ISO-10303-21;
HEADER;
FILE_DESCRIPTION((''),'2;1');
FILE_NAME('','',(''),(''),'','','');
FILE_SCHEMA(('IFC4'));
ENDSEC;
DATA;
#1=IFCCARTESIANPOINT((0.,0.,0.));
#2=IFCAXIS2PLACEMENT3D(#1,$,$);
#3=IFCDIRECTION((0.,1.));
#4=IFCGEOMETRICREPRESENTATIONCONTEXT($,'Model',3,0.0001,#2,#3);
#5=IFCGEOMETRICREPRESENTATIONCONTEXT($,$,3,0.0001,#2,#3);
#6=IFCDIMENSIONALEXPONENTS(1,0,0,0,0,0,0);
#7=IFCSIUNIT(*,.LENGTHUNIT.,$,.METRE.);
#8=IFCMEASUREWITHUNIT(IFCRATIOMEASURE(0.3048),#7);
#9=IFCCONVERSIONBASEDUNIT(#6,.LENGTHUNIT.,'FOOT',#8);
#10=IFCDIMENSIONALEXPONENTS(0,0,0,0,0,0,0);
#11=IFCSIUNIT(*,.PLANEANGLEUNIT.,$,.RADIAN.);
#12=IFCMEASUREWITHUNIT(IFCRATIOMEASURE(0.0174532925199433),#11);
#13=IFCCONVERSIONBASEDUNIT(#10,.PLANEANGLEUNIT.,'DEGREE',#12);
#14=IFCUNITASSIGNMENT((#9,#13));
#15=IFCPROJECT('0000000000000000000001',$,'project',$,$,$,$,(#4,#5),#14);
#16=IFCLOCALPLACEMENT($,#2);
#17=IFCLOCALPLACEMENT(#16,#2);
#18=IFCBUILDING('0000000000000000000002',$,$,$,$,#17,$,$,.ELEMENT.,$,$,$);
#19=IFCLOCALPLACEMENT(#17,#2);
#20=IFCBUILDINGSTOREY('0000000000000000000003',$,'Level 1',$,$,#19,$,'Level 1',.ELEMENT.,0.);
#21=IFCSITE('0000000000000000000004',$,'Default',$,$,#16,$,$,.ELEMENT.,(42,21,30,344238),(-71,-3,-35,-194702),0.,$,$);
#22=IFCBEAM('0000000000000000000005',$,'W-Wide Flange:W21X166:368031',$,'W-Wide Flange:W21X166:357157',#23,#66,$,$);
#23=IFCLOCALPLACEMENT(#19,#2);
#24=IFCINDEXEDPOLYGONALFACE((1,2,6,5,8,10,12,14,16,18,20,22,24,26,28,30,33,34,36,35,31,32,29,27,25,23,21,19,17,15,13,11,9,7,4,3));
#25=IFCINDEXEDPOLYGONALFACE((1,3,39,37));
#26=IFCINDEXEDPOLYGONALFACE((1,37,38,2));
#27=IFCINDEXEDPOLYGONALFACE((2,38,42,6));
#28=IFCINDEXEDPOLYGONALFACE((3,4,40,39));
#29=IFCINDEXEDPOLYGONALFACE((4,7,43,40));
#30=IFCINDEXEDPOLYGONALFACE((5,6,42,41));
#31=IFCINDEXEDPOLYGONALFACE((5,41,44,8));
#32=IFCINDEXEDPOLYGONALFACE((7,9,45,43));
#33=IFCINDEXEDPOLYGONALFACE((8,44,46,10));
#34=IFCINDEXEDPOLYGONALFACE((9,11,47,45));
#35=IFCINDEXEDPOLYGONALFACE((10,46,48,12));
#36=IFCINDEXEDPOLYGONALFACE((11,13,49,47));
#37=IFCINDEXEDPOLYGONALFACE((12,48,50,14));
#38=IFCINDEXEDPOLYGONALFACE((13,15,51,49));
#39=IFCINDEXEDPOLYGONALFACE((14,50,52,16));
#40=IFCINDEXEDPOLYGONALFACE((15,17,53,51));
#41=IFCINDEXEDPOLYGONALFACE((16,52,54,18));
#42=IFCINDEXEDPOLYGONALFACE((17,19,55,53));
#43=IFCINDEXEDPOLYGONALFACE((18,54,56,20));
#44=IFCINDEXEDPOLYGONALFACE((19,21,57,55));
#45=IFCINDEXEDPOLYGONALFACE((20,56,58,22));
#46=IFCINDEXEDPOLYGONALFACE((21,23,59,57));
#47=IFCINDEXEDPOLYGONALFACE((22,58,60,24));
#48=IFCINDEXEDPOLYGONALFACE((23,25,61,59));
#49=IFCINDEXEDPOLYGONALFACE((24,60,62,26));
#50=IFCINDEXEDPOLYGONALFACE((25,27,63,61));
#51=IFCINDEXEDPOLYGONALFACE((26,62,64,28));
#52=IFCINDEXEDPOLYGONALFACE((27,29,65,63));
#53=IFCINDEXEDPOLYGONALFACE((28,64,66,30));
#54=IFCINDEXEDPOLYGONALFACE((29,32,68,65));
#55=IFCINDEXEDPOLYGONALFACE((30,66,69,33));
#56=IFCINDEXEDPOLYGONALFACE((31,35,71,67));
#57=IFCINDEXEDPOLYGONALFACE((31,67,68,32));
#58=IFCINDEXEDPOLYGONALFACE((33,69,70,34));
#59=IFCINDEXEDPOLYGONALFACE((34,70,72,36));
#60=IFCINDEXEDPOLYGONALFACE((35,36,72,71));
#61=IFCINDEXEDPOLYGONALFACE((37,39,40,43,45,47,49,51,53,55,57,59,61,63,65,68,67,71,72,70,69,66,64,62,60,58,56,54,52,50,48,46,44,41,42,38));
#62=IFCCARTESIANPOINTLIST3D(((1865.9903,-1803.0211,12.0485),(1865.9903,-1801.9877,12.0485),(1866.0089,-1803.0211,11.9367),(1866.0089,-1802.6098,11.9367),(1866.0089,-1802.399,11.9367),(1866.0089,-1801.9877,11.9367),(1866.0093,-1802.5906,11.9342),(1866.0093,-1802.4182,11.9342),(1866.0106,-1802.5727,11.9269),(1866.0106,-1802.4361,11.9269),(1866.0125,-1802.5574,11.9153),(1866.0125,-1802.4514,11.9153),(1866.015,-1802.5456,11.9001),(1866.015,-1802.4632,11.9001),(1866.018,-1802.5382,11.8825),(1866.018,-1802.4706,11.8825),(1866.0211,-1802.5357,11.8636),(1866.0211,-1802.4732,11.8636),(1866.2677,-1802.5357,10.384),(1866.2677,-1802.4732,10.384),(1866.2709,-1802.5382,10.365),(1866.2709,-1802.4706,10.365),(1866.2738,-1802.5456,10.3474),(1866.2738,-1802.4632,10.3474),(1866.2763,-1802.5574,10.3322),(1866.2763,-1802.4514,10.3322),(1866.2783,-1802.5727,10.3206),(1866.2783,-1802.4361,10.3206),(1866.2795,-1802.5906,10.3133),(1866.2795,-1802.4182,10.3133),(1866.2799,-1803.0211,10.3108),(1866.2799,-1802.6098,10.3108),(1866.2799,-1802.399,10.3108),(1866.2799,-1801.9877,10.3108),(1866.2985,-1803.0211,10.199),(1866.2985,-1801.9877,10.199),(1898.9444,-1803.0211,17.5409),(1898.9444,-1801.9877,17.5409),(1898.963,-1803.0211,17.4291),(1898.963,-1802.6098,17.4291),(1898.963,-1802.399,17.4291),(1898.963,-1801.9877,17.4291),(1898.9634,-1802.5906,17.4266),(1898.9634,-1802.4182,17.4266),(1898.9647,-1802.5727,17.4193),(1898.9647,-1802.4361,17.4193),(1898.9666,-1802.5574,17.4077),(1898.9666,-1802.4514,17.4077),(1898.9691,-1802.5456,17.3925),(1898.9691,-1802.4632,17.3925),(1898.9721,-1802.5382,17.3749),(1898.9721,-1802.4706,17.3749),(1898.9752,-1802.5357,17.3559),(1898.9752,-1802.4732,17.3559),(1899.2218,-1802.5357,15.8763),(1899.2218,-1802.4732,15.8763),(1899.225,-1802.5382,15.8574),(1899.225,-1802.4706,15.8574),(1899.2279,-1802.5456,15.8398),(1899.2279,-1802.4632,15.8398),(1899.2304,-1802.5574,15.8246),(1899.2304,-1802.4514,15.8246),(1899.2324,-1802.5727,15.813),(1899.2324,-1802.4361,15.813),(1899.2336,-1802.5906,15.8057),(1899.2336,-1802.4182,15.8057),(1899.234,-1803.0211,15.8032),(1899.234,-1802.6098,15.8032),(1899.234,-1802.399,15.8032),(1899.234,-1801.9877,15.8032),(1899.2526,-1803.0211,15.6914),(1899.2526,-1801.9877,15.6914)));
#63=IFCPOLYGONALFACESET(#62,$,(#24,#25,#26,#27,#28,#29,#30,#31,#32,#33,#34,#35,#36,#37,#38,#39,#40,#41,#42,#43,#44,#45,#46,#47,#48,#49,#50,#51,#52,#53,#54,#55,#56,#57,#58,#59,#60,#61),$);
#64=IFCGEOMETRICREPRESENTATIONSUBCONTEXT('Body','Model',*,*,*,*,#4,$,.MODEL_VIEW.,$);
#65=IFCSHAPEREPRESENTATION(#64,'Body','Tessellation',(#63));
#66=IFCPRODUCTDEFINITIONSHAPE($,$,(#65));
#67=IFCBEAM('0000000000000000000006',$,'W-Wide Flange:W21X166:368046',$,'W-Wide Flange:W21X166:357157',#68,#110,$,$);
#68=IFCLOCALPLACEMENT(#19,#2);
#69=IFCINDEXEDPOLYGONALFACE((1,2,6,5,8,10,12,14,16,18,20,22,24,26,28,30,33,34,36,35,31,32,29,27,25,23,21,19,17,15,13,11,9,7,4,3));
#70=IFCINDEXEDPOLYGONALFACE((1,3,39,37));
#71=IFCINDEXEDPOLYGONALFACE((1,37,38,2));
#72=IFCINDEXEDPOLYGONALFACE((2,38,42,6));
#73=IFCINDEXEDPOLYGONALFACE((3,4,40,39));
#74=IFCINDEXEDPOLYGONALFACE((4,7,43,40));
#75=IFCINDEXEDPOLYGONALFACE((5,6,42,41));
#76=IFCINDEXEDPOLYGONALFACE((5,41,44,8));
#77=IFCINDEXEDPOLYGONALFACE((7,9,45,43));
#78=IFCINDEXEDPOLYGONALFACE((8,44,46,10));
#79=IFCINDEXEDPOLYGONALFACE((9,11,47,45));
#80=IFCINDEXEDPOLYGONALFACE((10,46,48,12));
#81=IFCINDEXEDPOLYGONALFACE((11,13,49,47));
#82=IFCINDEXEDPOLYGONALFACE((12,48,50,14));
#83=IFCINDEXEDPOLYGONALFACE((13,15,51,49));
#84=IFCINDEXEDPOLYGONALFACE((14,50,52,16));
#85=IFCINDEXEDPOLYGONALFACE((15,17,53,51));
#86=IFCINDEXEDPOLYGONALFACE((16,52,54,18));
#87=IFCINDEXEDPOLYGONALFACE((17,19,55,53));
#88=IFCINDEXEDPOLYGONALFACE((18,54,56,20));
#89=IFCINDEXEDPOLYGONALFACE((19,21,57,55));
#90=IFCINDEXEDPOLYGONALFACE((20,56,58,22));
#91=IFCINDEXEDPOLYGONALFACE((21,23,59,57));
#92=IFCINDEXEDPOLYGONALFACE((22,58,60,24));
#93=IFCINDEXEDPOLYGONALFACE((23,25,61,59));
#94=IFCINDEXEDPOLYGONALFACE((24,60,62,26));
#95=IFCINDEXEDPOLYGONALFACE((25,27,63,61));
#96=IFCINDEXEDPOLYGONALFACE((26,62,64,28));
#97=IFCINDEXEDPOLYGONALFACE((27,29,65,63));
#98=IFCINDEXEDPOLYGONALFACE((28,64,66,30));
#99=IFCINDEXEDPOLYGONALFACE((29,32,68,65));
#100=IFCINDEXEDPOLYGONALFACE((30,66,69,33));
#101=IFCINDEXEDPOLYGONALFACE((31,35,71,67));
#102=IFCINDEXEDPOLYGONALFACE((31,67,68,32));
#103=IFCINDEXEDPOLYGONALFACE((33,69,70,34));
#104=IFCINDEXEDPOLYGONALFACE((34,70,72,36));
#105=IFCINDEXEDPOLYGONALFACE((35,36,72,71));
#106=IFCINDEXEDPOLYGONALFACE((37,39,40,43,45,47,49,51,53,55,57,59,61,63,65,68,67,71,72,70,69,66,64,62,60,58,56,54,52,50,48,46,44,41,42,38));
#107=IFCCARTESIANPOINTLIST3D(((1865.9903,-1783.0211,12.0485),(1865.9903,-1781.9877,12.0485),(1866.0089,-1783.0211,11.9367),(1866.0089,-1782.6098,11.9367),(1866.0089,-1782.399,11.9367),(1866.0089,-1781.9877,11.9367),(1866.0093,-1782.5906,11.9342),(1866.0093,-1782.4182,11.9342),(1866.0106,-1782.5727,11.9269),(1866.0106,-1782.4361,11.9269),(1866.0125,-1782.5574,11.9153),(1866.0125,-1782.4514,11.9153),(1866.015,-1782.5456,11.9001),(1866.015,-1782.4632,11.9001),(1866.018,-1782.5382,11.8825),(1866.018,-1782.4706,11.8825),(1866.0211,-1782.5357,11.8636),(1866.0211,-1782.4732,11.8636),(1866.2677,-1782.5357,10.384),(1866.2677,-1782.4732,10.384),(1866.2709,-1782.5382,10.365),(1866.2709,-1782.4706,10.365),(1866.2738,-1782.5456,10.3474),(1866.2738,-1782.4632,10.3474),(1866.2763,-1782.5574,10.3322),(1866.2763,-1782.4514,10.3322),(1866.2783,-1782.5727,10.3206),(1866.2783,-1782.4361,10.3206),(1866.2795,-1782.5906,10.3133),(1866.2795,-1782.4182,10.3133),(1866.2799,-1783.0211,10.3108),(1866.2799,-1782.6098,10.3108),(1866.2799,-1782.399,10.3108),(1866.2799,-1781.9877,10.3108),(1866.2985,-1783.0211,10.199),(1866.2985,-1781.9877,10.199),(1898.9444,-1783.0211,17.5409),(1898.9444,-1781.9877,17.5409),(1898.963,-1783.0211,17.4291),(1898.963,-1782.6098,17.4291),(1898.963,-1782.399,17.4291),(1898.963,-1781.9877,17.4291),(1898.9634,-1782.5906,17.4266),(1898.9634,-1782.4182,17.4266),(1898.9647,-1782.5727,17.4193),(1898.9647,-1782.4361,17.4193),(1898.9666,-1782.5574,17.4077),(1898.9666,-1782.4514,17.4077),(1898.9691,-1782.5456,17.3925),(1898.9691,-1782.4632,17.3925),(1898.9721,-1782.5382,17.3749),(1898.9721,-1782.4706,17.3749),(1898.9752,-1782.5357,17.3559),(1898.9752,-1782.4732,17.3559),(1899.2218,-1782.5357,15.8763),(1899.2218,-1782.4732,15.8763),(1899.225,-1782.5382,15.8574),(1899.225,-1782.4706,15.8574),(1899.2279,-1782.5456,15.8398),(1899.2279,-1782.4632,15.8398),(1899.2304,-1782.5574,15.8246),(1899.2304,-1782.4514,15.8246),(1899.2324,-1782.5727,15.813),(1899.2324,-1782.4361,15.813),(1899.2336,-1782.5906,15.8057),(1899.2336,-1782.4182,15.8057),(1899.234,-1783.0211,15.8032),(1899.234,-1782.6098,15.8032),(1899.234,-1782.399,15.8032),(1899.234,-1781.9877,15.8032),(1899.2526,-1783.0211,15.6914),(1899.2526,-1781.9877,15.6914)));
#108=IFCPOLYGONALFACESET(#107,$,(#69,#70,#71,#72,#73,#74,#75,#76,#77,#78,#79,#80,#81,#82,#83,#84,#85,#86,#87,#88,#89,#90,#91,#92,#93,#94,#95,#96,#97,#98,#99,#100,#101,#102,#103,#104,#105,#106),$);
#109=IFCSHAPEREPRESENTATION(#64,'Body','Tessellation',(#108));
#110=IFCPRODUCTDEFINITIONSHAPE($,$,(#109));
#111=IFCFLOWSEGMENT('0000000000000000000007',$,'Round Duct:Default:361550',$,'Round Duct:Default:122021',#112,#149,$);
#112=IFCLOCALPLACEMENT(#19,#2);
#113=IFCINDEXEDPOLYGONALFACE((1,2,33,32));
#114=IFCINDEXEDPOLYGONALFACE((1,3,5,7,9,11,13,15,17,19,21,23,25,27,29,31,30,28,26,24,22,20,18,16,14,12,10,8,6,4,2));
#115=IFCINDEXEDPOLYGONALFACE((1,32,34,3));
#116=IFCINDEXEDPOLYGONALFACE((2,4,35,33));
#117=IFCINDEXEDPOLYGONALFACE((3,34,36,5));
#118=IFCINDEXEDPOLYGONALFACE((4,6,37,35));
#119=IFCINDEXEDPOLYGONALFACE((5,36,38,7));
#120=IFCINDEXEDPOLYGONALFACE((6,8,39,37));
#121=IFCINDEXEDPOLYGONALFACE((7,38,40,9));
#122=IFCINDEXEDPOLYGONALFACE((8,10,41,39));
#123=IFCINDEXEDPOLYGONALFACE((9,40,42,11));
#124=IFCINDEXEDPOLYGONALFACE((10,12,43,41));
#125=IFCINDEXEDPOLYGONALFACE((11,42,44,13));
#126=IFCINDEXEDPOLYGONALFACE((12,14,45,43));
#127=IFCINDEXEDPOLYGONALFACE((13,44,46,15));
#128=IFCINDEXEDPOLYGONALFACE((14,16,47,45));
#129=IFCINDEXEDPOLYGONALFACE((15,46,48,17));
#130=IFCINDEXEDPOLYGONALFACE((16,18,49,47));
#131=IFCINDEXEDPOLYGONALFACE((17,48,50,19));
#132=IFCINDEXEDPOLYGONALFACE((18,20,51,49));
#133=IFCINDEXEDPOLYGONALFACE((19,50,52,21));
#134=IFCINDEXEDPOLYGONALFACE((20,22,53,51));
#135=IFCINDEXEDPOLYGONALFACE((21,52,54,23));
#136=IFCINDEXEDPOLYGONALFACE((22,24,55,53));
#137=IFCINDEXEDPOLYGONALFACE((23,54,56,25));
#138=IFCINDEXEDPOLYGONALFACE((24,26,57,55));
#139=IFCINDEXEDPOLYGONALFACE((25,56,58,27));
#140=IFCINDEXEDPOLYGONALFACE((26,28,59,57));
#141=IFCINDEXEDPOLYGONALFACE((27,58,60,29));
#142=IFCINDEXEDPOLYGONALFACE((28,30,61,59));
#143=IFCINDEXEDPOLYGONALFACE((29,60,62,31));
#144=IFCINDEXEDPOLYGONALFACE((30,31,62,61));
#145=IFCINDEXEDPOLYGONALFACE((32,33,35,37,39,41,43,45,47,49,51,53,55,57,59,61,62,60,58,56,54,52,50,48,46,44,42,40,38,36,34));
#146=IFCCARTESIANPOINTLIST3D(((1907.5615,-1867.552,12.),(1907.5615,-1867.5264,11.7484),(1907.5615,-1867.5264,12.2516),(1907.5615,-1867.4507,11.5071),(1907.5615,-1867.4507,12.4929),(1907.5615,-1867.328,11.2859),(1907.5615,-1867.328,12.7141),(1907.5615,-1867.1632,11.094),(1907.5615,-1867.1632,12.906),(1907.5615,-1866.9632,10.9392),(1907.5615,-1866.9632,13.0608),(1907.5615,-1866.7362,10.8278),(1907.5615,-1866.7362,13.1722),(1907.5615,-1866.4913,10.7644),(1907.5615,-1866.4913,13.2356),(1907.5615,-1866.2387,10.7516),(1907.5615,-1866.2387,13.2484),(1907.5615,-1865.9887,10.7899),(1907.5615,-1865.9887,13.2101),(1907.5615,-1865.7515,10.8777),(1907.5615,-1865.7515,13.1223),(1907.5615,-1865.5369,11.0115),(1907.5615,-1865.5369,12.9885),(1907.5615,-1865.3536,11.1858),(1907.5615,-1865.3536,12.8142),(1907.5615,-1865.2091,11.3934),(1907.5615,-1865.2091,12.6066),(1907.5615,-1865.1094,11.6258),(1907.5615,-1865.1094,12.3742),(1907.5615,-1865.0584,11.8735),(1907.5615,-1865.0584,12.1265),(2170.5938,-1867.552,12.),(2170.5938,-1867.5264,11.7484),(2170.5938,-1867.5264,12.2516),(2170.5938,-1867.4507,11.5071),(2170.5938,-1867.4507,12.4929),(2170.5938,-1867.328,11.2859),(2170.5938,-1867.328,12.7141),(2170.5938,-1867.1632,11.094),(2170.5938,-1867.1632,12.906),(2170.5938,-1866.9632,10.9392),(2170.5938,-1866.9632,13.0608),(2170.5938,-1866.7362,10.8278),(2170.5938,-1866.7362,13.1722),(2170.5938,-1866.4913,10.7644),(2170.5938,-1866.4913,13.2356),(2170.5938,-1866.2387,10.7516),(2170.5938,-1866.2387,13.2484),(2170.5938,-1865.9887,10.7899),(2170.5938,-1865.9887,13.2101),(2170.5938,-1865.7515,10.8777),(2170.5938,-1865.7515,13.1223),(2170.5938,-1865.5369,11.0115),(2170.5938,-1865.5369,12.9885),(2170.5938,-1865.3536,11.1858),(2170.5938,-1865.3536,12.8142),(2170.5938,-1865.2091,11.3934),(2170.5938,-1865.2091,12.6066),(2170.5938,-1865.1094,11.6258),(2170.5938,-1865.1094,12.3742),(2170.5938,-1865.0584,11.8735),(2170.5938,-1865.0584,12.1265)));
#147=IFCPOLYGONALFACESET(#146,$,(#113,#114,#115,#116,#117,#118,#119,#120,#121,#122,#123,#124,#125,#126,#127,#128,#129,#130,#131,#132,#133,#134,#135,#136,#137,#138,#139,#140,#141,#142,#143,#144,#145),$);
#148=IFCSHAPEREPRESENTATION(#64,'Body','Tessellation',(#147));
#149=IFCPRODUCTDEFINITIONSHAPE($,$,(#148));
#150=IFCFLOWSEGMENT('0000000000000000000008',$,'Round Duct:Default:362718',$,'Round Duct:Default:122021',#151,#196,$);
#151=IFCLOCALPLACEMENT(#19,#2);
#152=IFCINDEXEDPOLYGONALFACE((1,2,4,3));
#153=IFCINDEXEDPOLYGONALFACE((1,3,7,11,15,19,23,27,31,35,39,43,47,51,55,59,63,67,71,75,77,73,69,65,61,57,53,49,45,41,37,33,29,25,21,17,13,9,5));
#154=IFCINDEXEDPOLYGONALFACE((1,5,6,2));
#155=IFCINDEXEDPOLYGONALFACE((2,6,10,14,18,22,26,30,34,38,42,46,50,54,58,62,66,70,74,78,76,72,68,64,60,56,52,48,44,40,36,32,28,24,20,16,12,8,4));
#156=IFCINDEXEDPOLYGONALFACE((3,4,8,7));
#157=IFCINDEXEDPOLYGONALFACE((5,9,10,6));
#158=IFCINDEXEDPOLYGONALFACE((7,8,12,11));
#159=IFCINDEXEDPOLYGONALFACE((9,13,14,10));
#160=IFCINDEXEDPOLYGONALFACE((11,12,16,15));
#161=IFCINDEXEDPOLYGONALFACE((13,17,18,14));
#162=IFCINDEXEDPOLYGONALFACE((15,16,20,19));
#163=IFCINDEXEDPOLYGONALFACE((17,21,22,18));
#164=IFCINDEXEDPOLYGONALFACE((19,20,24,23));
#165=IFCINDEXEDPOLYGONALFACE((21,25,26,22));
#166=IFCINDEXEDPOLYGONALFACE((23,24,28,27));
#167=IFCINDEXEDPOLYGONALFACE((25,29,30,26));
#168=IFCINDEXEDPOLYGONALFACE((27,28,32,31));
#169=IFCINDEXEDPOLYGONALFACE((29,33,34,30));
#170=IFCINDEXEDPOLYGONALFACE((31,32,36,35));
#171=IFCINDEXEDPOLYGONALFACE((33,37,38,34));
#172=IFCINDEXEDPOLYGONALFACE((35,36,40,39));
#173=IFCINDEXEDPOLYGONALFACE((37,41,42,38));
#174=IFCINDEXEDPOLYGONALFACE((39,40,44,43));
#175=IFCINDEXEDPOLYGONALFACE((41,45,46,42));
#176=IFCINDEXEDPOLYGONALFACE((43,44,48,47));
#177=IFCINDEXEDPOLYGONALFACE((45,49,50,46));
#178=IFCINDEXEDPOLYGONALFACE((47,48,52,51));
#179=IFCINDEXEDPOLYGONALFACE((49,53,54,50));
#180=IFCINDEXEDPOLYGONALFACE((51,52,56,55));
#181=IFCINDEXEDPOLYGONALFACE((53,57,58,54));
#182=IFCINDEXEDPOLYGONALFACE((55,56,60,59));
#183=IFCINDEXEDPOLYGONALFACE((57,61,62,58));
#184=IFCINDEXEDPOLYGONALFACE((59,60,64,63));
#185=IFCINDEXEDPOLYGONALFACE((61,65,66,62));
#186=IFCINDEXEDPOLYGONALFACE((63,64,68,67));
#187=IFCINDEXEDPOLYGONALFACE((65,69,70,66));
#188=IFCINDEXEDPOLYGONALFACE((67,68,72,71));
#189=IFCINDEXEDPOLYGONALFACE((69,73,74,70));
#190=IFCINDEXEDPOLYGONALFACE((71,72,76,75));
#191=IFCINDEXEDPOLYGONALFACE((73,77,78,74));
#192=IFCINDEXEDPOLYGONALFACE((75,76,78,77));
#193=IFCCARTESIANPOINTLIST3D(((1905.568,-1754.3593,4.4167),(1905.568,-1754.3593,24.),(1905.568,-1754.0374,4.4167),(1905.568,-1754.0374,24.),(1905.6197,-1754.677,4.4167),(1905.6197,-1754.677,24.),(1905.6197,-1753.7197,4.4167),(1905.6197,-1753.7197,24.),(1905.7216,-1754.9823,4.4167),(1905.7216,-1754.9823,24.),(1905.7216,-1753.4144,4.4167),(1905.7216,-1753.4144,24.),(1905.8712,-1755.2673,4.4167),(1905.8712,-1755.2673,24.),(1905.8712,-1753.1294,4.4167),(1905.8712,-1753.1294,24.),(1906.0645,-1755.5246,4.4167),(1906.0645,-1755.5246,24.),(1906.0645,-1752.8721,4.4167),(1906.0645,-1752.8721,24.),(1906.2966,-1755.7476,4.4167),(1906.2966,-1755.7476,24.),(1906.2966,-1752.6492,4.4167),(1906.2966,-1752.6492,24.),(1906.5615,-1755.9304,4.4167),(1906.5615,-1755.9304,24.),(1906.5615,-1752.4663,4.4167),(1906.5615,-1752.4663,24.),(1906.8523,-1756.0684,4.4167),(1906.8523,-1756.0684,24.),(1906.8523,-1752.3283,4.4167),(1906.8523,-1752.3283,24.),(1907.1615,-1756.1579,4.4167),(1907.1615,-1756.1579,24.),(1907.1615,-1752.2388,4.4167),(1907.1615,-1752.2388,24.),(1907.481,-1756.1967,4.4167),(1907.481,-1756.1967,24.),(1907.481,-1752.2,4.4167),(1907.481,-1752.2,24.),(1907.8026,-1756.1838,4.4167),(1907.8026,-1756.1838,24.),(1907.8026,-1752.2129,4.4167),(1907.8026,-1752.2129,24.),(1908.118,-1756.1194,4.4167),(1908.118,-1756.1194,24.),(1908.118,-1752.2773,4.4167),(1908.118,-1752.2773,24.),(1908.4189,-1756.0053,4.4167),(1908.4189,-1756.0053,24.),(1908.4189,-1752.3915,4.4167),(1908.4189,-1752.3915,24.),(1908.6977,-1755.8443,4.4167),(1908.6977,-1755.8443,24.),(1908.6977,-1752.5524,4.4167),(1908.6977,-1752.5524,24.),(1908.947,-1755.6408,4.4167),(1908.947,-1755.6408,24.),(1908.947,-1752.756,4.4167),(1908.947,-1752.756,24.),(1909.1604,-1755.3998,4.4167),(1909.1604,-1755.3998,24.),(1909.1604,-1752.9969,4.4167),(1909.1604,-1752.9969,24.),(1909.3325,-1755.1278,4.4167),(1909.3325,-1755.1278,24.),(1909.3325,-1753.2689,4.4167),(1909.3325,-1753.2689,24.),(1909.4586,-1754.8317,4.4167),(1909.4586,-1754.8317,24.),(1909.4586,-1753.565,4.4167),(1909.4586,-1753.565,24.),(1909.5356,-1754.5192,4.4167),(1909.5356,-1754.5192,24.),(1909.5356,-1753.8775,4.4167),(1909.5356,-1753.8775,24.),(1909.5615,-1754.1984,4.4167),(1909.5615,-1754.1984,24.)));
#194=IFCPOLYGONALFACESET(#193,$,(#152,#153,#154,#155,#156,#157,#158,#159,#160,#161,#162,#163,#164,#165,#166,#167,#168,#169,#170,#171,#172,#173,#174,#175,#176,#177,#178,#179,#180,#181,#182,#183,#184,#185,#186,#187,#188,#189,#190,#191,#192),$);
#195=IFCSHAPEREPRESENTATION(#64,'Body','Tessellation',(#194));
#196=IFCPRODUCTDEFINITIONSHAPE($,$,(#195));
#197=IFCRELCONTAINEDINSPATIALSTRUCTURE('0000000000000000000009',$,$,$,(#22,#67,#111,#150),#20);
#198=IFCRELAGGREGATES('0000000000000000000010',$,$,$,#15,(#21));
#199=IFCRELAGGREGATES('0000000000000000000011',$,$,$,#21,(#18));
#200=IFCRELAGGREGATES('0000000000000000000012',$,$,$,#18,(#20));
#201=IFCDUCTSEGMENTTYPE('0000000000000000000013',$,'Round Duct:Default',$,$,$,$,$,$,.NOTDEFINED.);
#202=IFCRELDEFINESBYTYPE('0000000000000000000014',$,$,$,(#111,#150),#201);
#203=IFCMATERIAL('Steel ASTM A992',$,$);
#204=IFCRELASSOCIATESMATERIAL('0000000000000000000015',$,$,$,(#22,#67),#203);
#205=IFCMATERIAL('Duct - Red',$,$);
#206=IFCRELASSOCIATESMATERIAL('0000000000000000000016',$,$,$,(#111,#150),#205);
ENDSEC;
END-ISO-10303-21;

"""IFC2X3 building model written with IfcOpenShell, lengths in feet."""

from ifc_helpers import new_model, entity, si_unit, converted_unit, direction, frame, frame_2d, origin, place, context, subcontext, project, spatial, circle, i_section, extrude, material, type_object, element, save


model = new_model("IFC2X3")

# Units and contexts
model_context = context("Model", 3, precision=0.0001, world=origin(), true_north=direction((0.0, 1.0)))
context_of_model = context(None, 3, precision=0.0001, world=origin(), true_north=direction((0.0, 1.0)))
body_context = subcontext(model_context, "Body", "Model", "MODEL_VIEW")
ifc_project = project(units=[converted_unit("LENGTHUNIT", "FOOT", entity("IfcRatioMeasure", 0.3048), si_unit("LENGTHUNIT", "METRE"), dimensions=[1, 0, 0, 0, 0, 0, 0]), converted_unit("PLANEANGLEUNIT", "DEGREE", entity("IfcRatioMeasure", 0.0174532925199433), si_unit("PLANEANGLEUNIT", "RADIAN"), dimensions=[0, 0, 0, 0, 0, 0, 0])], contexts=[model_context, context_of_model])

# Site, building, storey
site_placement = place(None, origin())
site = spatial("IfcSite", under=ifc_project, at=site_placement, Name="Default", CompositionType="ELEMENT", RefLatitude=(42, 21, 30, 344238), RefLongitude=(-71, -3, -35, -194702), RefElevation=0.0)
building_placement = place(site_placement, origin())
building = spatial("IfcBuilding", under=site, at=building_placement, CompositionType="ELEMENT")
storey_placement = place(building_placement, origin())
storey = spatial("IfcBuildingStorey", under=building, at=storey_placement, Name="Level 1", LongName="Level 1", CompositionType="ELEMENT", Elevation=0.0)

# Shared definitions
ifc_material_1 = material(Name="Steel ASTM A992")

# Beams
beam_1_placement = place(storey_placement, frame((1865.8276, -1802.5044, 12.0214), z_axis=(-0.164399, 0.0, 0.986394), x_axis=(0.986394, 0.0, 0.164399)))
element("IfcBeam", 1, at=beam_1_placement, inside=storey, material=ifc_material_1, Name="W-Wide Flange:W21X166:368031", ObjectType="W-Wide Flange:W21X166:357157", context=body_context, shape_type="SweptSolid", body=[
    extrude(i_section(OverallWidth=1.0333, OverallDepth=1.875, WebThickness=0.0625, FlangeThickness=0.1133, FilletRadius=0.0742, at=frame_2d((0.0, 0.0), x_axis=(0.0, 1.0))), frame((0.165, 0.0, -0.9375), z_axis=(1.0, 0.0, 0.0), x_axis=(0.0, 0.0, -1.0)), (0.0, 0.0, 1.0), 33.4087),
])
beam_2_placement = place(storey_placement, frame((1865.8276, -1782.5044, 12.0214), z_axis=(-0.164399, 0.0, 0.986394), x_axis=(0.986394, 0.0, 0.164399)))
element("IfcBeam", 2, at=beam_2_placement, inside=storey, material=ifc_material_1, Name="W-Wide Flange:W21X166:368046", ObjectType="W-Wide Flange:W21X166:357157", context=body_context, shape_type="SweptSolid", body=[
    extrude(i_section(OverallWidth=1.0333, OverallDepth=1.875, WebThickness=0.0625, FlangeThickness=0.1133, FilletRadius=0.0742, at=frame_2d((0.0, 0.0), x_axis=(0.0, 1.0))), frame((0.165, 0.0, -0.9375), z_axis=(1.0, 0.0, 0.0), x_axis=(0.0, 0.0, -1.0)), (0.0, 0.0, 1.0), 33.4087),
])

# Flow segments
ifc_material_2 = material(Name="Duct - Red")
duct_segment_type = type_object("IfcDuctSegmentType", Name="Round Duct:Default", PredefinedType="NOTDEFINED")
flow_segment_1_placement = place(storey_placement, origin())
element("IfcFlowSegment", 3, at=flow_segment_1_placement, inside=storey, type_object=duct_segment_type, material=ifc_material_2, Name="Round Duct:Default:361550", ObjectType="Round Duct:Default:122021", context=body_context, shape_type="SweptSolid", body=[
    extrude(circle(Radius=1.25, at=frame_2d((0.0, 0.0), x_axis=(1.0, 0.0))), frame((1907.5615, -1866.302, 12.0), z_axis=(1.0, 0.0, 0.0), x_axis=(0.0, -1.0, 0.0)), (0.0, 0.0, 1.0), 263.0323),
])
flow_segment_2_placement = place(storey_placement, origin())
element("IfcFlowSegment", 4, at=flow_segment_2_placement, inside=storey, type_object=duct_segment_type, material=ifc_material_2, Name="Round Duct:Default:362718", ObjectType="Round Duct:Default:122021", context=body_context, shape_type="SweptSolid", body=[
    extrude(circle(Radius=2.0, at=frame_2d((0.0, 0.0), x_axis=(1.0, 0.0))), frame((1907.5615, -1754.1984, 4.4167)), (0.0, 0.0, 1.0), 19.5833),
])

save(model, "model.ifc")
